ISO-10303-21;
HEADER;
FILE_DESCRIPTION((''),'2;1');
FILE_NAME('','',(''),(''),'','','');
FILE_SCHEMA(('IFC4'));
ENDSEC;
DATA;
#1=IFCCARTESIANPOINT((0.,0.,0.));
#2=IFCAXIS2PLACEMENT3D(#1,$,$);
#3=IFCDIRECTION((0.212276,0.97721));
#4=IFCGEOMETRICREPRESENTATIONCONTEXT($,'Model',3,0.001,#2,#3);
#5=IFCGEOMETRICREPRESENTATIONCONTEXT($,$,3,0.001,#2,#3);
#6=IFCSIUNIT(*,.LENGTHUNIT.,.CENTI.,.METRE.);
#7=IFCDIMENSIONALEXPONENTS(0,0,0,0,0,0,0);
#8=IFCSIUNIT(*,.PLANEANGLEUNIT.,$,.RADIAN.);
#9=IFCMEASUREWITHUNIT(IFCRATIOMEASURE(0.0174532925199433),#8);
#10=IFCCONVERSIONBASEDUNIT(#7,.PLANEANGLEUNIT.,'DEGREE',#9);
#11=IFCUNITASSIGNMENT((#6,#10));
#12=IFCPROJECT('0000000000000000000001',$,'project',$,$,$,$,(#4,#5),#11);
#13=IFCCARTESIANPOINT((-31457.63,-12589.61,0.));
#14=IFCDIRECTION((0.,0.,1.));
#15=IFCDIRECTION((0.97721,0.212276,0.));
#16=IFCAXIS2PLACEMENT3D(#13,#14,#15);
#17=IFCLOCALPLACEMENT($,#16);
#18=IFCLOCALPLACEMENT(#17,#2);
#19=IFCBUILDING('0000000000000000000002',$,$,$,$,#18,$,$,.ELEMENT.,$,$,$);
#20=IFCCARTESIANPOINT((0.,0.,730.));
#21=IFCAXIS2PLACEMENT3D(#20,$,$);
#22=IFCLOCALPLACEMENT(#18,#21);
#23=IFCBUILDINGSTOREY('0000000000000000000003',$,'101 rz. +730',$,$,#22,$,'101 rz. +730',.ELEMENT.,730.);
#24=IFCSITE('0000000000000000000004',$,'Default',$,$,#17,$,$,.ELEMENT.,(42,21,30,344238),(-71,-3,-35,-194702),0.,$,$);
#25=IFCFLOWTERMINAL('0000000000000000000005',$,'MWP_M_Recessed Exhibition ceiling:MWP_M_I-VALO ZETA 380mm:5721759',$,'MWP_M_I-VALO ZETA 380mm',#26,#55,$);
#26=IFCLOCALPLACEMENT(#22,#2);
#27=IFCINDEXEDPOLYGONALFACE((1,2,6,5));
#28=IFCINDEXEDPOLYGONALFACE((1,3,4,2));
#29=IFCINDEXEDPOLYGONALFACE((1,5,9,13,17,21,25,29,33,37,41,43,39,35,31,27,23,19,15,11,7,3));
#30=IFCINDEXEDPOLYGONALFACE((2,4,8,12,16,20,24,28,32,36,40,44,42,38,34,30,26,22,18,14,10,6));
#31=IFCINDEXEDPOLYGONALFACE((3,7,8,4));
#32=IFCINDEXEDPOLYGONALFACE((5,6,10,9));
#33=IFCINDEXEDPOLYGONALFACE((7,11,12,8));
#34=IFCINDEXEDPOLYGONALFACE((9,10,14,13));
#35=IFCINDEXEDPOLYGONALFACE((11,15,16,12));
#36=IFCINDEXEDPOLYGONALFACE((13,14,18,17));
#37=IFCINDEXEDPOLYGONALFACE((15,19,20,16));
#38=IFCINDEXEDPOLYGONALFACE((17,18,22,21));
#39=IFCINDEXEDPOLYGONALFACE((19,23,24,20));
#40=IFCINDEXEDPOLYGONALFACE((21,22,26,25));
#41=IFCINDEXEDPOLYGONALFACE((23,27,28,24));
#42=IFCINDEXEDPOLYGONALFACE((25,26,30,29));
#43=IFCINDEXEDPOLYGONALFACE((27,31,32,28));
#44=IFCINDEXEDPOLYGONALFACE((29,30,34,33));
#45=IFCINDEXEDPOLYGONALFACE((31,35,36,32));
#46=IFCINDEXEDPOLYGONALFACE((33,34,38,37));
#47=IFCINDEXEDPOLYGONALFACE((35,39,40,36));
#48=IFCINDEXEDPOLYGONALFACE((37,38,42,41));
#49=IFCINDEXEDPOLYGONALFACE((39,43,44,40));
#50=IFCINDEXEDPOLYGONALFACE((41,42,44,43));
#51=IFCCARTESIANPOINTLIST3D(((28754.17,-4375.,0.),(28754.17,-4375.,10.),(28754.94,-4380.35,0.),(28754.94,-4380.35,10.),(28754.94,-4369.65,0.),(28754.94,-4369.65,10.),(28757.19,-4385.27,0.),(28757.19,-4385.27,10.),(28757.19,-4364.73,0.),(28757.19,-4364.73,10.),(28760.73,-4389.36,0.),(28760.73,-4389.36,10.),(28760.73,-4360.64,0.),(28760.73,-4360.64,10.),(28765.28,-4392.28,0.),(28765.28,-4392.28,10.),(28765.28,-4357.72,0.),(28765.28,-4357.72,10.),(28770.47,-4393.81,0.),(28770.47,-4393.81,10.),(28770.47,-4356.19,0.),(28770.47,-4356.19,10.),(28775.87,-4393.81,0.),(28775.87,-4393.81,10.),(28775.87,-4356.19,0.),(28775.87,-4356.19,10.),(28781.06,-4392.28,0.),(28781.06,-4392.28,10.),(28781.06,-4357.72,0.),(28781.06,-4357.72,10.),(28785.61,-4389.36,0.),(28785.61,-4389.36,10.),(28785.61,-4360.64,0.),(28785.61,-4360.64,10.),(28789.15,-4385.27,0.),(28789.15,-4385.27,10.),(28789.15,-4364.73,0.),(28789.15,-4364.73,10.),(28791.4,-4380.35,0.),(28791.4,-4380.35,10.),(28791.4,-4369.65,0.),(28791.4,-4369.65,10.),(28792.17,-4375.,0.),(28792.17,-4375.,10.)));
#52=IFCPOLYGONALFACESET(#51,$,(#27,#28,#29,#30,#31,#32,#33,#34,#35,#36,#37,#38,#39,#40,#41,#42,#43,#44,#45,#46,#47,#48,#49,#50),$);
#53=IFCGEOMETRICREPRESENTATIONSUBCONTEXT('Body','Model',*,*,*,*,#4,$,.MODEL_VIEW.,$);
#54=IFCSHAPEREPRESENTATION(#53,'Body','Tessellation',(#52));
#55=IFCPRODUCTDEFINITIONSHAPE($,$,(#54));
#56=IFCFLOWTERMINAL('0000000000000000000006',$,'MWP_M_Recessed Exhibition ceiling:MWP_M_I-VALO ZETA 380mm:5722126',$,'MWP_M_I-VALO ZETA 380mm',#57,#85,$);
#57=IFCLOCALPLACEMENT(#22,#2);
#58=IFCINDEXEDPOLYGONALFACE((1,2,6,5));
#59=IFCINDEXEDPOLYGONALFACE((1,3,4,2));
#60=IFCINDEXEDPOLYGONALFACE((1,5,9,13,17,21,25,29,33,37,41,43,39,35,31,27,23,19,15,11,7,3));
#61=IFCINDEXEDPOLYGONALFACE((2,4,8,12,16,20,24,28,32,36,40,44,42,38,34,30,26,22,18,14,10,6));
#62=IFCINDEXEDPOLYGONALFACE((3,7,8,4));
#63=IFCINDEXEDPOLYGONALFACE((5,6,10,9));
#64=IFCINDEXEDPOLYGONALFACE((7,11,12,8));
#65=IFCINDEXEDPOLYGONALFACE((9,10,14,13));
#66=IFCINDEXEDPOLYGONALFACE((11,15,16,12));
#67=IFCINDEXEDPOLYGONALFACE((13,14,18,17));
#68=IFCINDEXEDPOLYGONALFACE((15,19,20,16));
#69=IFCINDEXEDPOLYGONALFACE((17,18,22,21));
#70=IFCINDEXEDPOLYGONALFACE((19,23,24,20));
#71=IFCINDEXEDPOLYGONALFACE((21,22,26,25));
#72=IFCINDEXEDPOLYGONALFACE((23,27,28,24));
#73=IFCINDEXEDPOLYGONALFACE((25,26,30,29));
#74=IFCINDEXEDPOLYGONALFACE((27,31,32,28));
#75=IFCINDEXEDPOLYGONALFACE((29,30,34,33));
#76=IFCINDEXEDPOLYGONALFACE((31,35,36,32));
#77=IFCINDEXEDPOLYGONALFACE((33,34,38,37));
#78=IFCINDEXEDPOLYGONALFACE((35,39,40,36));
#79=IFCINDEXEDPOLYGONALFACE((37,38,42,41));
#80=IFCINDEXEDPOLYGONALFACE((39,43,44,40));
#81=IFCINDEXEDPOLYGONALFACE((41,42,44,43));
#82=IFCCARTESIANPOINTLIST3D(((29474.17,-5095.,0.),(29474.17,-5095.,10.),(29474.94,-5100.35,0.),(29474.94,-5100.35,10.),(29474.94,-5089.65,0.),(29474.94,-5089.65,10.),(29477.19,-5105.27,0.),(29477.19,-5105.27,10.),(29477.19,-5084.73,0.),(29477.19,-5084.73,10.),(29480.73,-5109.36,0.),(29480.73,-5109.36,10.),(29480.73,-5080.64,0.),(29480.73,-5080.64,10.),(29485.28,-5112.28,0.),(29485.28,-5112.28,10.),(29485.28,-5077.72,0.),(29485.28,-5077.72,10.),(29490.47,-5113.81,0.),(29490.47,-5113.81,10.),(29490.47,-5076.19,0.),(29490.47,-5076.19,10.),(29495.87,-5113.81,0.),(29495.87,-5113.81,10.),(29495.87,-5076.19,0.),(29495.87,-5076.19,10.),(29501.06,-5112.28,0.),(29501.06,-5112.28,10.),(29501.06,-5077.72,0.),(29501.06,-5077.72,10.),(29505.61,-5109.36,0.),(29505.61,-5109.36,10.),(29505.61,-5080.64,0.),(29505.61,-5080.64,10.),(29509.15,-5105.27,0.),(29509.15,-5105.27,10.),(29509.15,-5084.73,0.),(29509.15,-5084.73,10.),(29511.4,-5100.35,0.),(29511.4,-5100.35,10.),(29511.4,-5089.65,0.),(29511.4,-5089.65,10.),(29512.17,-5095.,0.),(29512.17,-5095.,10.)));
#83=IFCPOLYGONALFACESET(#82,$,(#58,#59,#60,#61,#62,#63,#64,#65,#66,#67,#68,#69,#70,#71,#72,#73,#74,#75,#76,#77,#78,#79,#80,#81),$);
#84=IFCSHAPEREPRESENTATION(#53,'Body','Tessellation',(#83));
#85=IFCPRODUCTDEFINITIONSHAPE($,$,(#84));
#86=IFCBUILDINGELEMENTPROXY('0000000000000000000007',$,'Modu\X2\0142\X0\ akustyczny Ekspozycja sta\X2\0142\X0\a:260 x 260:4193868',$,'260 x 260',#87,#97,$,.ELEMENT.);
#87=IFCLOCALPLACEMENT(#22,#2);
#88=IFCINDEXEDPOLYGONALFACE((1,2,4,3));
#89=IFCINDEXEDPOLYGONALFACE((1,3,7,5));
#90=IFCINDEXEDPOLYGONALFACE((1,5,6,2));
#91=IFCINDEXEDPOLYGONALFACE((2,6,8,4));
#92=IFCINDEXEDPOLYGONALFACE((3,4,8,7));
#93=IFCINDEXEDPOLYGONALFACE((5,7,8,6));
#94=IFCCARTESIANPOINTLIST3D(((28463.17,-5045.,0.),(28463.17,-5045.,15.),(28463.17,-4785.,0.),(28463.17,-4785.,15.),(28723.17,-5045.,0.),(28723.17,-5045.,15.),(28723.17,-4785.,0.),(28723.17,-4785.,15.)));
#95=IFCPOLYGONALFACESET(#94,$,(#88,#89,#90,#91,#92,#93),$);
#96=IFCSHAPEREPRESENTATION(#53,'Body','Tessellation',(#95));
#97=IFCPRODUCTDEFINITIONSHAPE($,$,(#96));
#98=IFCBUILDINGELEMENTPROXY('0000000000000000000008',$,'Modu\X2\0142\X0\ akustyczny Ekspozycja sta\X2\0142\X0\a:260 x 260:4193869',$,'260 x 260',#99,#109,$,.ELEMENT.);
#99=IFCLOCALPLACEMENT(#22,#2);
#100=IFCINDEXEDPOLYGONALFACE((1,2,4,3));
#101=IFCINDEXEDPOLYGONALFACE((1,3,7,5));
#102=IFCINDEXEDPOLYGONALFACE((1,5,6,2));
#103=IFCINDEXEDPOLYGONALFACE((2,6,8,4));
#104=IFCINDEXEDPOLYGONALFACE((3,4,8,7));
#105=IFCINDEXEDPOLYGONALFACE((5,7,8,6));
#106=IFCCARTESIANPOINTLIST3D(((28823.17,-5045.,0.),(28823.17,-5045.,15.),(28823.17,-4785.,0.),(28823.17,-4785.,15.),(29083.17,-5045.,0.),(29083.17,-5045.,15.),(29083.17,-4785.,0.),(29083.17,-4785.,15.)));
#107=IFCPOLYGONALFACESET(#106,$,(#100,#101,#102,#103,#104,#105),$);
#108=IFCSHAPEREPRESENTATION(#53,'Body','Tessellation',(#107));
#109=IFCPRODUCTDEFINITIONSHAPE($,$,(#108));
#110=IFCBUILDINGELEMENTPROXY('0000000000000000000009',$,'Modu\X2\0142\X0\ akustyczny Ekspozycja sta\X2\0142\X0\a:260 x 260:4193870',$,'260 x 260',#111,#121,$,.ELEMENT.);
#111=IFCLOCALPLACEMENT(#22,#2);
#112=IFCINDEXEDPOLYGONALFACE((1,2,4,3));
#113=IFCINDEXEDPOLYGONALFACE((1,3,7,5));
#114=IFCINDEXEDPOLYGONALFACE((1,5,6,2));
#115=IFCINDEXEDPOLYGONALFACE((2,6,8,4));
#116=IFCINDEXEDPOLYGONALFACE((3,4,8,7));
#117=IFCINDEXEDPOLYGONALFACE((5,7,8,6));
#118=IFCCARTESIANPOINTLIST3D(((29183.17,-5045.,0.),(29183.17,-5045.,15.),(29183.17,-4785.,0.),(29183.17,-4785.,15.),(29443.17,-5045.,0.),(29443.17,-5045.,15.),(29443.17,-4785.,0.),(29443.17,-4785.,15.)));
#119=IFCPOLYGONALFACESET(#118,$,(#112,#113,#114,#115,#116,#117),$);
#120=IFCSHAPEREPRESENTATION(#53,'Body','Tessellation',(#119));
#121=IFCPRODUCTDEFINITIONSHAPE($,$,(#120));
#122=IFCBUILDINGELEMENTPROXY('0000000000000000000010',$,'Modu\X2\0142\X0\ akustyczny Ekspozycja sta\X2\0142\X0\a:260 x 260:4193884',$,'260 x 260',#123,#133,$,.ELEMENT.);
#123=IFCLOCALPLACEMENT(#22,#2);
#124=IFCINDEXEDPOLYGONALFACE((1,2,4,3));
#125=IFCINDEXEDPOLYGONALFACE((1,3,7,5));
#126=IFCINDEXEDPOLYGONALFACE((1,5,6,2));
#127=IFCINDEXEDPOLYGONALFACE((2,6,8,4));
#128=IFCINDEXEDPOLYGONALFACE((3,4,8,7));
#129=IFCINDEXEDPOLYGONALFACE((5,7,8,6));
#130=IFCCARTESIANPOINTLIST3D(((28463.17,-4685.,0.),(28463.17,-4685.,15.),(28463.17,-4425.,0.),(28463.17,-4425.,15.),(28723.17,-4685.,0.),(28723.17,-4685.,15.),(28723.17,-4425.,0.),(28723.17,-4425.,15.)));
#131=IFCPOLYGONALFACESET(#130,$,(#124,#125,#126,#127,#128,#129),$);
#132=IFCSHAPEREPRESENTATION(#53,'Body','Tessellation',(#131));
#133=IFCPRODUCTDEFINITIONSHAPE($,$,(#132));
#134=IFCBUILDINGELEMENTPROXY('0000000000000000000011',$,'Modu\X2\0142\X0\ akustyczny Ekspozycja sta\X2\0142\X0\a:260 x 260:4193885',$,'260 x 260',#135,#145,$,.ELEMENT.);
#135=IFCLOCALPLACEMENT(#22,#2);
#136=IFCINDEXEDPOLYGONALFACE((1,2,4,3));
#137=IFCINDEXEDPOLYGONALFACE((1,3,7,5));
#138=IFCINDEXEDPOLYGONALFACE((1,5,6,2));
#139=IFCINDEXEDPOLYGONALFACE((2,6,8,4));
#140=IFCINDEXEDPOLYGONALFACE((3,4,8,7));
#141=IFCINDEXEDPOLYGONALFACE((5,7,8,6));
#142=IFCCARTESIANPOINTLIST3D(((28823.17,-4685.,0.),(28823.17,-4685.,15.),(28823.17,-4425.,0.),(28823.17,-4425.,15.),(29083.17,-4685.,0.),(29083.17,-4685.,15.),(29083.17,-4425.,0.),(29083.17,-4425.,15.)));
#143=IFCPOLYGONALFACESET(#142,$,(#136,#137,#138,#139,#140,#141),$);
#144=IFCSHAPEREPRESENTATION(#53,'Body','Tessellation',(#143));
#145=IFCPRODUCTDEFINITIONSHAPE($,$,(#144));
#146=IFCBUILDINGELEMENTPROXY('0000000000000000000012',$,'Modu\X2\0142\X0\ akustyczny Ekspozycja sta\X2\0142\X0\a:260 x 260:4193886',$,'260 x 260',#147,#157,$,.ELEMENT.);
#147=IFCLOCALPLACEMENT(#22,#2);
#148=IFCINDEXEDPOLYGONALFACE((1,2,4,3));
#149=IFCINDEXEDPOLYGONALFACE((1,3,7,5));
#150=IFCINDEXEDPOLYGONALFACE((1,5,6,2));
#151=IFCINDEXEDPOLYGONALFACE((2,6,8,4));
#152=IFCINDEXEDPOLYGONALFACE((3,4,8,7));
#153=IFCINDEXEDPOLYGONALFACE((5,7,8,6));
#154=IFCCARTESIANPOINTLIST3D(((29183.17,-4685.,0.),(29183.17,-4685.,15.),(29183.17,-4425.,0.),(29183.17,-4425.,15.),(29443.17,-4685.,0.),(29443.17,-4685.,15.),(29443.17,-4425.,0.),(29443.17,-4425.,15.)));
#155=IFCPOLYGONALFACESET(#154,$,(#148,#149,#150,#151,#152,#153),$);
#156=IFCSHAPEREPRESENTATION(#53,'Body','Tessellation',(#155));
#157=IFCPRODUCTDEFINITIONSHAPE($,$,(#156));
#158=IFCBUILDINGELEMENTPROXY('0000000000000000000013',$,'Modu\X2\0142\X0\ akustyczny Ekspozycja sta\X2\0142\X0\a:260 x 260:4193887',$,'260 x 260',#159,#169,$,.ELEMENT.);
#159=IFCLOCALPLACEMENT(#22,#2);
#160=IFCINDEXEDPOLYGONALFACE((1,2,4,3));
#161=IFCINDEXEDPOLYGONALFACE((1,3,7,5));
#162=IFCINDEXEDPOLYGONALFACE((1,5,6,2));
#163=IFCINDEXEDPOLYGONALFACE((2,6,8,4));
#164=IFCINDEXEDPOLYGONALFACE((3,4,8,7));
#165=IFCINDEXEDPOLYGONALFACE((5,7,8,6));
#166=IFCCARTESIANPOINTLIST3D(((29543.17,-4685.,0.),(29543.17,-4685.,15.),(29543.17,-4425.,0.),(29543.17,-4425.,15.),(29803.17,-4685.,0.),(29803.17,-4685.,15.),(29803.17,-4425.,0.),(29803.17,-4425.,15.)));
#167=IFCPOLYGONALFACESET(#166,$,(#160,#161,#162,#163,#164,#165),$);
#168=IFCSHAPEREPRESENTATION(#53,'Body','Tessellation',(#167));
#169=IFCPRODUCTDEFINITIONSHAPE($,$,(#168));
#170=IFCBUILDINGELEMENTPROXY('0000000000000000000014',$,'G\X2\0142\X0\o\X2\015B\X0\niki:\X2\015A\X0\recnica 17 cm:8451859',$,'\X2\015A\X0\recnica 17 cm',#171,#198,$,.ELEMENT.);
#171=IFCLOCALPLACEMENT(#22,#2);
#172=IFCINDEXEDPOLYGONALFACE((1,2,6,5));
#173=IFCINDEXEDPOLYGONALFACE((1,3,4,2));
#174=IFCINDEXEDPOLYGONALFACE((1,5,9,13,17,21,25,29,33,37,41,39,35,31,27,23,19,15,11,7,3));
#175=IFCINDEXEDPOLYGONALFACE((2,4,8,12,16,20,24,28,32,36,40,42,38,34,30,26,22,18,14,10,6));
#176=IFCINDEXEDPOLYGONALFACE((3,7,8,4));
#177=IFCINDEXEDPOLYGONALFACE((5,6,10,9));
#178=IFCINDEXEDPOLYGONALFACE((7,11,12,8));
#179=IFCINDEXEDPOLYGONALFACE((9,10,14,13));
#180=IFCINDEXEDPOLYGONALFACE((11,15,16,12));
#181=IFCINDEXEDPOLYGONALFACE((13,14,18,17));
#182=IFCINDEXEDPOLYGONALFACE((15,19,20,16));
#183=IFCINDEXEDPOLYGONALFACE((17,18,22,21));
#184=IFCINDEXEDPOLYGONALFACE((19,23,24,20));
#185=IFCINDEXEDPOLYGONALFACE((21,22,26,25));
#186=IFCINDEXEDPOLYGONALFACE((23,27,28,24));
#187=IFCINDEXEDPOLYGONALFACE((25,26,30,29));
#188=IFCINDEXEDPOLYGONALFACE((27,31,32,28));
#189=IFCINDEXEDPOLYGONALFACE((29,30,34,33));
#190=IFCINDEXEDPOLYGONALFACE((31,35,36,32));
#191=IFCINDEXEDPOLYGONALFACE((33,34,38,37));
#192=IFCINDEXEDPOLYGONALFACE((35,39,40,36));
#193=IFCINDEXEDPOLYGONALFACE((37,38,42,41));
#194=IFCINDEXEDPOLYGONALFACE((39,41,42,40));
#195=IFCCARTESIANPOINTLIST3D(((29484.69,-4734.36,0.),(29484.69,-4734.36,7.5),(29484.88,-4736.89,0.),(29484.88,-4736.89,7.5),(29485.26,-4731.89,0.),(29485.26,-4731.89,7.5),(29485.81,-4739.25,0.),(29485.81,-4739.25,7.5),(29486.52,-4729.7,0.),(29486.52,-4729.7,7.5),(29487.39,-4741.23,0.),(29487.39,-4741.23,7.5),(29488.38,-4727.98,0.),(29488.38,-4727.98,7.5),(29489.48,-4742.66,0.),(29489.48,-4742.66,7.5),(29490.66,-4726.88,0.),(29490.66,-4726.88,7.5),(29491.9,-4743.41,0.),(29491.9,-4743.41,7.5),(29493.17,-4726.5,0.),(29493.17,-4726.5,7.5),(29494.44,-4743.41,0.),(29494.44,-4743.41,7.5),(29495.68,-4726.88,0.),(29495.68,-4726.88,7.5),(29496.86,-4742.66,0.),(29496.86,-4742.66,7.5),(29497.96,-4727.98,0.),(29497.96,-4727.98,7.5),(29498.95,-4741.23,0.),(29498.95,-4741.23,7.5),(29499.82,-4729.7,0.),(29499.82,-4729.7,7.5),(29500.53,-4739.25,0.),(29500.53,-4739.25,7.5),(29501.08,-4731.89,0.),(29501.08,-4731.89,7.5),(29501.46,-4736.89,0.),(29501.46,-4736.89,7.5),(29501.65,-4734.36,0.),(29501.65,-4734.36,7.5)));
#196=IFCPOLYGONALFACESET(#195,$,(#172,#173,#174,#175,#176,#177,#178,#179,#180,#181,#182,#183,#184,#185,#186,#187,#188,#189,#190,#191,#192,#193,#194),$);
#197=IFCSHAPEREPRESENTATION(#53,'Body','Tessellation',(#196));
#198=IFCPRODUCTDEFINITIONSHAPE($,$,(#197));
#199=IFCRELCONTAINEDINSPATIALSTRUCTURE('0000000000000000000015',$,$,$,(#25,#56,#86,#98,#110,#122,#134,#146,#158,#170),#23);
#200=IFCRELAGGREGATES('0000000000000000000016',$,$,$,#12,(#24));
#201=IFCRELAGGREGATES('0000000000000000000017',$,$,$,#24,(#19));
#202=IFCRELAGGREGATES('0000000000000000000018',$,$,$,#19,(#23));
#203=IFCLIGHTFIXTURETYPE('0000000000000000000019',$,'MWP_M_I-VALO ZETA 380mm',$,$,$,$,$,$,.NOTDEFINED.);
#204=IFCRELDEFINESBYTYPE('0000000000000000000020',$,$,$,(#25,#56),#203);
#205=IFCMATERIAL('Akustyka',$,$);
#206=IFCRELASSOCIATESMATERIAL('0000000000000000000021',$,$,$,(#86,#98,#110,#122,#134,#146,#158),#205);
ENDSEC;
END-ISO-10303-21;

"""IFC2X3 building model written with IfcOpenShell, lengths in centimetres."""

from ifc_helpers import new_model, entity, si_unit, converted_unit, direction, frame, frame_2d, origin, origin_2d_with_axis, place, context, subcontext, project, spatial, rectangle, circle, extrude, source, transform, mapped, material, type_object, type_shapes, element, save


model = new_model("IFC2X3")

# Units and contexts
model_context = context("Model", 3, precision=0.001, world=origin(), true_north=direction((0.212276, 0.97721)))
context_of_model = context(None, 3, precision=0.001, world=origin(), true_north=direction((0.212276, 0.97721)))
body_context = subcontext(model_context, "Body", "Model", "MODEL_VIEW")
ifc_project = project(units=[si_unit("LENGTHUNIT", "METRE", prefix="CENTI"), converted_unit("PLANEANGLEUNIT", "DEGREE", entity("IfcRatioMeasure", 0.0174532925199433), si_unit("PLANEANGLEUNIT", "RADIAN"), dimensions=[0, 0, 0, 0, 0, 0, 0])], contexts=[model_context, context_of_model])

# Site, building, storey
site_placement = place(None, frame((-31457.63, -12589.61, 0.0), z_axis=(0.0, 0.0, 1.0), x_axis=(0.97721, 0.212276, 0.0)))
site = spatial("IfcSite", under=ifc_project, at=site_placement, Name="Default", CompositionType="ELEMENT", RefLatitude=(42, 21, 30, 344238), RefLongitude=(-71, -3, -35, -194702), RefElevation=0.0)
building_placement = place(site_placement, origin())
building = spatial("IfcBuilding", under=site, at=building_placement, CompositionType="ELEMENT")
storey_placement = place(building_placement, frame((0.0, 0.0, 730.0)))
storey = spatial("IfcBuildingStorey", under=building, at=storey_placement, Name="101 rz. +730", LongName="101 rz. +730", CompositionType="ELEMENT", Elevation=730.0)

# Flow terminals
light_fixture_type = type_object("IfcLightFixtureType", Name="MWP_M_I-VALO ZETA 380mm", PredefinedType="NOTDEFINED")
shared_shape_1 = source(origin(), body_context, "Body", "SweptSolid", [
    extrude(circle(Radius=19.0, at=frame_2d((0.0, 0.0), x_axis=(1.0, 0.0))), frame((0.0, 0.0, -10.0)), (0.0, 0.0, 1.0), 10.0),
])
type_shapes(light_fixture_type, [shared_shape_1])
for number, where, z_axis, x_axis, name in (
    (1, (28773.17, -4375.0, 0.0), (0.0, 0.0, -1.0), (1.0, 0.0, 0.0), "MWP_M_Recessed Exhibition ceiling:MWP_M_I-VALO ZETA 380mm:5721759"),
    (2, (29493.17, -5095.0, 0.0), (0.0, 0.0, -1.0), (1.0, 0.0, 0.0), "MWP_M_Recessed Exhibition ceiling:MWP_M_I-VALO ZETA 380mm:5722126"),
):
    element("IfcFlowTerminal", number, at=place(storey_placement, frame(where, z_axis=z_axis, x_axis=x_axis)), inside=storey, type_object=light_fixture_type, Name=name, ObjectType="MWP_M_I-VALO ZETA 380mm", context=body_context, shape_type="MappedRepresentation", body=[
        mapped(shared_shape_1, transform((0.0, 0.0, 0.0), scale=1.0)),
    ])

# Building element proxies
ifc_material_1 = material(Name="Akustyka")
shared_shape_2 = source(origin(), body_context, "Body", "SweptSolid", [
    extrude(rectangle(XDim=260.0, YDim=260.0, at=origin_2d_with_axis()), frame((0.0, 0.0, -15.0), z_axis=(0.0, 0.0, 1.0), x_axis=(-1.0, 0.0, 0.0)), (0.0, 0.0, 1.0), 15.0),
])
for number, where, z_axis, x_axis, name in (
    (3, (28593.17, -4915.0, 0.0), (0.0, 0.0, -1.0), (1.0, 0.0, 0.0), "Moduł akustyczny Ekspozycja stała:260 x 260:4193868"),
    (4, (28953.17, -4915.0, 0.0), (0.0, 0.0, -1.0), (1.0, 0.0, 0.0), "Moduł akustyczny Ekspozycja stała:260 x 260:4193869"),
    (5, (29313.17, -4915.0, 0.0), (0.0, 0.0, -1.0), (1.0, 0.0, 0.0), "Moduł akustyczny Ekspozycja stała:260 x 260:4193870"),
    (6, (28593.17, -4555.0, 0.0), (0.0, 0.0, -1.0), (1.0, 0.0, 0.0), "Moduł akustyczny Ekspozycja stała:260 x 260:4193884"),
    (7, (28953.17, -4555.0, 0.0), (0.0, 0.0, -1.0), (1.0, 0.0, 0.0), "Moduł akustyczny Ekspozycja stała:260 x 260:4193885"),
    (8, (29313.17, -4555.0, 0.0), (0.0, 0.0, -1.0), (1.0, 0.0, 0.0), "Moduł akustyczny Ekspozycja stała:260 x 260:4193886"),
    (9, (29673.17, -4555.0, 0.0), (0.0, 0.0, -1.0), (1.0, 0.0, 0.0), "Moduł akustyczny Ekspozycja stała:260 x 260:4193887"),
):
    element("IfcBuildingElementProxy", number, at=place(storey_placement, frame(where, z_axis=z_axis, x_axis=x_axis)), inside=storey, material=ifc_material_1, Name=name, ObjectType="260 x 260", CompositionType="ELEMENT", context=body_context, shape_type="MappedRepresentation", body=[
        mapped(shared_shape_2, transform((0.0, 0.0, 0.0), scale=1.0)),
    ])
shared_shape_3 = source(origin(), body_context, "Body", "SweptSolid", [
    extrude(circle(Radius=8.5, at=frame_2d((0.0, 0.0), x_axis=(1.0, 0.0))), frame((0.0, 0.0, 0.0), z_axis=(0.0, 0.0, 1.0), x_axis=(0.0, 1.0, 0.0)), (0.0, 0.0, 1.0), 7.5),
])
for number, where, name in (
    (10, (29493.17, -4735.0, 0.0), "Głośniki:Śrecnica 17 cm:8451859"),
):
    element("IfcBuildingElementProxy", number, at=place(storey_placement, frame(where)), inside=storey, Name=name, ObjectType="Śrecnica 17 cm", CompositionType="ELEMENT", context=body_context, shape_type="MappedRepresentation", body=[
        mapped(shared_shape_3, transform((0.0, 0.0, 0.0), scale=1.0)),
    ])

save(model, "model.ifc")
